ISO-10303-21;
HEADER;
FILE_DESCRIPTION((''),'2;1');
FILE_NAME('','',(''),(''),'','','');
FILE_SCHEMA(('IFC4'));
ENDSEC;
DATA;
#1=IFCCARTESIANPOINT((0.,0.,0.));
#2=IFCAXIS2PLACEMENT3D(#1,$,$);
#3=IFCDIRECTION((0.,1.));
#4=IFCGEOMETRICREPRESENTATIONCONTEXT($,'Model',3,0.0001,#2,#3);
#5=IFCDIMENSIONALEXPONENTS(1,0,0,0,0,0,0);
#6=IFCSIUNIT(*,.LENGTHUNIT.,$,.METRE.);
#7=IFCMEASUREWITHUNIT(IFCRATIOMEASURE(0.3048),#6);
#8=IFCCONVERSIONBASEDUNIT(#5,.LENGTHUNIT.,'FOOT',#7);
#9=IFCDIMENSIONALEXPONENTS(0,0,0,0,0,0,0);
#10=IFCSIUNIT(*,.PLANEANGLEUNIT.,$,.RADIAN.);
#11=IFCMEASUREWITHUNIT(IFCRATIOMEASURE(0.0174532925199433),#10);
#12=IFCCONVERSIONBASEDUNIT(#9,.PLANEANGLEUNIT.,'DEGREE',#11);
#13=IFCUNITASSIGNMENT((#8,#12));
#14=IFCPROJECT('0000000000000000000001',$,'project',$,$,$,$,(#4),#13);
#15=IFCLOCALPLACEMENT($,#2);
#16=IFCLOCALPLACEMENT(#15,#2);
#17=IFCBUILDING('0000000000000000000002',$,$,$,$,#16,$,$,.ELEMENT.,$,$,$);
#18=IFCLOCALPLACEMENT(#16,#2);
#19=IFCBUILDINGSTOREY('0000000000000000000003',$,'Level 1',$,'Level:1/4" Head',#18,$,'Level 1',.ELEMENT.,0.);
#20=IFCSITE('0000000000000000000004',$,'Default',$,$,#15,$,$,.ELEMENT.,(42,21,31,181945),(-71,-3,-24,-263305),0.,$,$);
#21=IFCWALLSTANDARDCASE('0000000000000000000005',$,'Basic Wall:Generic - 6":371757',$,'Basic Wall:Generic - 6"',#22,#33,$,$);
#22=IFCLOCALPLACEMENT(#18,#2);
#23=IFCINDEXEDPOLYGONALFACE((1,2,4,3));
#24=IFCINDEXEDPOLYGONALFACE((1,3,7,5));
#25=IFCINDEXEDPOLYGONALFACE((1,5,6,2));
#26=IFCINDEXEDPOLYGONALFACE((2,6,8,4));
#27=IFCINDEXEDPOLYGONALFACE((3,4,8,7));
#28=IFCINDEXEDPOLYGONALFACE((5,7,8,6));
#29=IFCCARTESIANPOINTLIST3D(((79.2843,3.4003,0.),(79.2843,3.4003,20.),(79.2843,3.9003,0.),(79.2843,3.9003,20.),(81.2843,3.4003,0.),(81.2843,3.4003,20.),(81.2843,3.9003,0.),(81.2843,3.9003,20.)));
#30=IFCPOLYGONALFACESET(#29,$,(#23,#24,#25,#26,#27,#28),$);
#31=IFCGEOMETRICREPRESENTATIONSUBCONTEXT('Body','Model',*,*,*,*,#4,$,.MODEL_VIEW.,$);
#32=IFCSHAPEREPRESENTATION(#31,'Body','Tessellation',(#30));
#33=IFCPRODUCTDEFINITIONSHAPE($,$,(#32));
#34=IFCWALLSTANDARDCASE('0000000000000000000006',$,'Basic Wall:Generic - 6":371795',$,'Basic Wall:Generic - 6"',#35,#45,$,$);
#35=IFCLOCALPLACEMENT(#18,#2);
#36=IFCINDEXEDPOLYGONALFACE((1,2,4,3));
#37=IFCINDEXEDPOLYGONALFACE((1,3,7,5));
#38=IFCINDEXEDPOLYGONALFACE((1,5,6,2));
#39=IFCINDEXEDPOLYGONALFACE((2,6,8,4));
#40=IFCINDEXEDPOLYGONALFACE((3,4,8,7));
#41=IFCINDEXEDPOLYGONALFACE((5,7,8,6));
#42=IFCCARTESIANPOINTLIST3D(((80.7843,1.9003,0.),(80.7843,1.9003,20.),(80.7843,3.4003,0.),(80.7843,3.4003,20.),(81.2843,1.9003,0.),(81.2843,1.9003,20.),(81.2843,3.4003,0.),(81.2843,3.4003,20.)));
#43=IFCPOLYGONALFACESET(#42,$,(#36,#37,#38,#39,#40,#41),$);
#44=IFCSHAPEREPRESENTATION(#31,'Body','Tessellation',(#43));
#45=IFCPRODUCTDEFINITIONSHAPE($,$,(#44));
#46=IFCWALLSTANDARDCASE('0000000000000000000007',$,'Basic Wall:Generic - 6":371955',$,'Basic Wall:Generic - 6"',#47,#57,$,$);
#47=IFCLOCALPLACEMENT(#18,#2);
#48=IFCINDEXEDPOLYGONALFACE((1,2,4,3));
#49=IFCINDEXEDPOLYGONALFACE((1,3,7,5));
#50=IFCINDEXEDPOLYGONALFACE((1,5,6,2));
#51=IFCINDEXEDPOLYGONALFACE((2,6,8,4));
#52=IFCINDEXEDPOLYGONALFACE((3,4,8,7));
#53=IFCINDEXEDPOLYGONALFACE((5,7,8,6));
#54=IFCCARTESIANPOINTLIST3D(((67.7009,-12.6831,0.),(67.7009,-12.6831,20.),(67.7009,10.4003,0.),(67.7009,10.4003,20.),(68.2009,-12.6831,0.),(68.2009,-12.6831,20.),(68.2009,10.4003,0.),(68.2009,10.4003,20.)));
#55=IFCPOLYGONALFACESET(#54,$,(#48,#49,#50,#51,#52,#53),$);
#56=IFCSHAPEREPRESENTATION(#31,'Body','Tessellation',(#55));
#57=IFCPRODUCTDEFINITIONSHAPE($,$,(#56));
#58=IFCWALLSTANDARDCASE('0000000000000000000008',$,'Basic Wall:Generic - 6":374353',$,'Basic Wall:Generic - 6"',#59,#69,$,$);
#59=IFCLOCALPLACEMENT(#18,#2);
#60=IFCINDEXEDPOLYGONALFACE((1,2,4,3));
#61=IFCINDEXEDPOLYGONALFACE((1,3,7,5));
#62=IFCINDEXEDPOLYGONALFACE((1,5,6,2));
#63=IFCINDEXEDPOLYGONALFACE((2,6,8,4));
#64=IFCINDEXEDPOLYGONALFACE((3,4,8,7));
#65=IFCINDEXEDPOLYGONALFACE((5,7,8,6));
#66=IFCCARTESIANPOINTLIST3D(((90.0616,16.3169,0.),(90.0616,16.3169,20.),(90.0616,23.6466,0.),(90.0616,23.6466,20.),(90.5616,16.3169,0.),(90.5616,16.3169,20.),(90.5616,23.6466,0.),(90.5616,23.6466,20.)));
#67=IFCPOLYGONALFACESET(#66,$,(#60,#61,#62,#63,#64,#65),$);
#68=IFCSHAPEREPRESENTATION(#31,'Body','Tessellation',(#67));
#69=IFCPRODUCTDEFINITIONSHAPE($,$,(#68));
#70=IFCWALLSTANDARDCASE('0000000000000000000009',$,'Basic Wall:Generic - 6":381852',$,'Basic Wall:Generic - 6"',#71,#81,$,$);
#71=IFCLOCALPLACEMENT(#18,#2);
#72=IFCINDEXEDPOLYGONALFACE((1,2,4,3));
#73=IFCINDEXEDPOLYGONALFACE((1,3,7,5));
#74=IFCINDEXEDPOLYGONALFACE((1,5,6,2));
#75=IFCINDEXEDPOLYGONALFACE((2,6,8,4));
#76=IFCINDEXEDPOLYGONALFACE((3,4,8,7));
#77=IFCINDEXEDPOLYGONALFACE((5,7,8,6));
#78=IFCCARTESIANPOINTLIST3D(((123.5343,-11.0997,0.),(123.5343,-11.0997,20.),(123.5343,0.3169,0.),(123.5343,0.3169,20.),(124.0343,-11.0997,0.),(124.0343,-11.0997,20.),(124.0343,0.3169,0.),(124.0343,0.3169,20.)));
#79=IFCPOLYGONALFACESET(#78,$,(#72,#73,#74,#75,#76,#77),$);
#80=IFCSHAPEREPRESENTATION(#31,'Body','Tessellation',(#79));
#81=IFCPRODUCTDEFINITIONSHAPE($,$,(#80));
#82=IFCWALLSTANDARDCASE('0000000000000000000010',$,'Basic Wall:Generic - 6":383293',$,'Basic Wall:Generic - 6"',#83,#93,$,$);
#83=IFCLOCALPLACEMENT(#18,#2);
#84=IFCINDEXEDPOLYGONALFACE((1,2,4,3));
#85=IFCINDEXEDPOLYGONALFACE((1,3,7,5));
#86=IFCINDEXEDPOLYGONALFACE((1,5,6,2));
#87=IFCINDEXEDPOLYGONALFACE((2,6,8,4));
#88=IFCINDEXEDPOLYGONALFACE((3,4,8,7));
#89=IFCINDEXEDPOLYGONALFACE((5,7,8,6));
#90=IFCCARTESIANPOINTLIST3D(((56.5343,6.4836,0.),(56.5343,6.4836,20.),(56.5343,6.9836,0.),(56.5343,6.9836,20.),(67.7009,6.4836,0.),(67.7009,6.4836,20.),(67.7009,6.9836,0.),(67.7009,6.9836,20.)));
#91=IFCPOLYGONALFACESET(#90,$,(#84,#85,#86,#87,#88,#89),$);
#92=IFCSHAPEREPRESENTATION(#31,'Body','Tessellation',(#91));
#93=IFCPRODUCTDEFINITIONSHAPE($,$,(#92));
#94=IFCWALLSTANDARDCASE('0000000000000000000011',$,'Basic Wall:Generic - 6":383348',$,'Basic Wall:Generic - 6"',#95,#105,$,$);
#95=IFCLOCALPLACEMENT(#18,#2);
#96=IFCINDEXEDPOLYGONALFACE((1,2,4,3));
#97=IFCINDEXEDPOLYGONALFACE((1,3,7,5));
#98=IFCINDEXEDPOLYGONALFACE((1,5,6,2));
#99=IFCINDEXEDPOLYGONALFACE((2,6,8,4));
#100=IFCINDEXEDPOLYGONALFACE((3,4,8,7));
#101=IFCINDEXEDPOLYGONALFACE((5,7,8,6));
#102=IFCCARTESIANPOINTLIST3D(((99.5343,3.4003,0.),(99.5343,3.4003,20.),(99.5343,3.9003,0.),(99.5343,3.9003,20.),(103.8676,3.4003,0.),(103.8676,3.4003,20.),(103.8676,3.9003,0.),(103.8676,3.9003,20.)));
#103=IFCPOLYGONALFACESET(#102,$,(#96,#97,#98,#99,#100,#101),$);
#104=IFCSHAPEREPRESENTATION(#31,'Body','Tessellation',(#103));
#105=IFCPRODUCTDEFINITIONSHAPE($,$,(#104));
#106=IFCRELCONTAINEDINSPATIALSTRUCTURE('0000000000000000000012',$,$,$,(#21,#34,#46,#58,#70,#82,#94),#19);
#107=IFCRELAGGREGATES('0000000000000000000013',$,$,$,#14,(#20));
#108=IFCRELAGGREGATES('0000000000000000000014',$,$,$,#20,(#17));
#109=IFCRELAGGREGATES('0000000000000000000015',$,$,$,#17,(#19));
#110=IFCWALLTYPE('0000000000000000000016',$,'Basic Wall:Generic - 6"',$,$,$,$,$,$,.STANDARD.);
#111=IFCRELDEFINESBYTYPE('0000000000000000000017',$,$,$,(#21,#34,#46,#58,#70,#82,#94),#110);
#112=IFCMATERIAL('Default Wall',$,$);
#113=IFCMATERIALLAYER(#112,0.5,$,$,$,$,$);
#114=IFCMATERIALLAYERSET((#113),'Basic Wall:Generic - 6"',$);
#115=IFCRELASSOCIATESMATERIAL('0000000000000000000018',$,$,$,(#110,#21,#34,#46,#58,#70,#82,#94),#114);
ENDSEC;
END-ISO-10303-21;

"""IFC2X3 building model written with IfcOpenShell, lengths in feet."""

from ifc_helpers import new_model, entity, si_unit, converted_unit, direction, frame, frame_2d, origin, place, context, subcontext, project, spatial, rectangle, extrude, material, layer, layer_set, layer_usage, type_object, element, save


model = new_model("IFC2X3")

# Units and contexts
model_context = context("Model", 3, precision=0.0001, world=origin(), true_north=direction((0.0, 1.0)))
body_context = subcontext(model_context, "Body", "Model", "MODEL_VIEW")
ifc_project = project(units=[converted_unit("LENGTHUNIT", "FOOT", entity("IfcRatioMeasure", 0.3048), si_unit("LENGTHUNIT", "METRE"), dimensions=[1, 0, 0, 0, 0, 0, 0]), converted_unit("PLANEANGLEUNIT", "DEGREE", entity("IfcRatioMeasure", 0.0174532925199433), si_unit("PLANEANGLEUNIT", "RADIAN"), dimensions=[0, 0, 0, 0, 0, 0, 0])], contexts=[model_context])

# Site, building, storey
site_placement = place(None, origin())
site = spatial("IfcSite", under=ifc_project, at=site_placement, Name="Default", CompositionType="ELEMENT", RefLatitude=(42, 21, 31, 181945), RefLongitude=(-71, -3, -24, -263305), RefElevation=0.0)
building_placement = place(site_placement, origin())
building = spatial("IfcBuilding", under=site, at=building_placement, CompositionType="ELEMENT")
storey_placement = place(building_placement, origin())
storey = spatial("IfcBuildingStorey", under=building, at=storey_placement, Name="Level 1", ObjectType="Level:1/4\" Head", LongName="Level 1", CompositionType="ELEMENT", Elevation=0.0)

# Walls
ifc_material = material(Name="Default Wall")
ifc_layer_1 = layer(ifc_material, 0.5)
ifc_layer_set_1 = layer_set([ifc_layer_1], Name="Basic Wall:Generic - 6\"")
wall_type_1 = type_object("IfcWallType", Name="Basic Wall:Generic - 6\"", PredefinedType="STANDARD", material=ifc_layer_set_1)
ifc_layer_usage_1 = layer_usage(ifc_layer_set_1, "AXIS2", "NEGATIVE", 0.25)
wall_1_placement = place(storey_placement, frame((79.2843, 3.6503, 0.0)))
element("IfcWallStandardCase", 1, at=wall_1_placement, inside=storey, type_object=wall_type_1, material=ifc_layer_usage_1, Name="Basic Wall:Generic - 6\":371757", ObjectType="Basic Wall:Generic - 6\"", context=body_context, shape_type="SweptSolid", body=[
    extrude(rectangle(XDim=2.0, YDim=0.5, at=frame_2d((1.0, 0.0), x_axis=(-1.0, 0.0))), origin(), (0.0, 0.0, 1.0), 20.0),
])
ifc_layer_usage_2 = layer_usage(ifc_layer_set_1, "AXIS2", "NEGATIVE", 0.25)
wall_2_placement = place(storey_placement, frame((81.0343, 3.4003, 0.0), z_axis=(0.0, 0.0, 1.0), x_axis=(0.0, -1.0, 0.0)))
element("IfcWallStandardCase", 2, at=wall_2_placement, inside=storey, type_object=wall_type_1, material=ifc_layer_usage_2, Name="Basic Wall:Generic - 6\":371795", ObjectType="Basic Wall:Generic - 6\"", context=body_context, shape_type="SweptSolid", body=[
    extrude(rectangle(XDim=1.5, YDim=0.5, at=frame_2d((0.75, 0.0), x_axis=(-1.0, 0.0))), origin(), (0.0, 0.0, 1.0), 20.0),
])
ifc_layer_usage_3 = layer_usage(ifc_layer_set_1, "AXIS2", "NEGATIVE", 0.25)
wall_3_placement = place(storey_placement, frame((67.9509, 10.4003, 0.0), z_axis=(0.0, 0.0, 1.0), x_axis=(0.0, -1.0, 0.0)))
element("IfcWallStandardCase", 3, at=wall_3_placement, inside=storey, type_object=wall_type_1, material=ifc_layer_usage_3, Name="Basic Wall:Generic - 6\":371955", ObjectType="Basic Wall:Generic - 6\"", context=body_context, shape_type="SweptSolid", body=[
    extrude(rectangle(XDim=23.0833, YDim=0.5, at=frame_2d((11.5417, 0.0), x_axis=(-1.0, 0.0))), origin(), (0.0, 0.0, 1.0), 20.0),
])
ifc_layer_usage_4 = layer_usage(ifc_layer_set_1, "AXIS2", "NEGATIVE", 0.25)
wall_4_placement = place(storey_placement, frame((90.3116, 16.3169, 0.0), z_axis=(0.0, 0.0, 1.0), x_axis=(0.0, 1.0, 0.0)))
element("IfcWallStandardCase", 4, at=wall_4_placement, inside=storey, type_object=wall_type_1, material=ifc_layer_usage_4, Name="Basic Wall:Generic - 6\":374353", ObjectType="Basic Wall:Generic - 6\"", context=body_context, shape_type="SweptSolid", body=[
    extrude(rectangle(XDim=7.3297, YDim=0.5, at=frame_2d((3.6648, 0.0), x_axis=(-1.0, 0.0))), origin(), (0.0, 0.0, 1.0), 20.0),
])
ifc_layer_usage_5 = layer_usage(ifc_layer_set_1, "AXIS2", "NEGATIVE", 0.25)
wall_5_placement = place(storey_placement, frame((123.7843, 0.3169, 0.0), z_axis=(0.0, 0.0, 1.0), x_axis=(0.0, -1.0, 0.0)))
element("IfcWallStandardCase", 5, at=wall_5_placement, inside=storey, type_object=wall_type_1, material=ifc_layer_usage_5, Name="Basic Wall:Generic - 6\":381852", ObjectType="Basic Wall:Generic - 6\"", context=body_context, shape_type="SweptSolid", body=[
    extrude(rectangle(XDim=11.4167, YDim=0.5, at=frame_2d((5.7083, 0.0), x_axis=(-1.0, 0.0))), origin(), (0.0, 0.0, 1.0), 20.0),
])
ifc_layer_usage_6 = layer_usage(ifc_layer_set_1, "AXIS2", "NEGATIVE", 0.25)
wall_6_placement = place(storey_placement, frame((56.5343, 6.7336, 0.0)))
element("IfcWallStandardCase", 6, at=wall_6_placement, inside=storey, type_object=wall_type_1, material=ifc_layer_usage_6, Name="Basic Wall:Generic - 6\":383293", ObjectType="Basic Wall:Generic - 6\"", context=body_context, shape_type="SweptSolid", body=[
    extrude(rectangle(XDim=11.1667, YDim=0.5, at=frame_2d((5.5833, 0.0), x_axis=(-1.0, 0.0))), origin(), (0.0, 0.0, 1.0), 20.0),
])
ifc_layer_usage_7 = layer_usage(ifc_layer_set_1, "AXIS2", "NEGATIVE", 0.25)
wall_7_placement = place(storey_placement, frame((99.5343, 3.6503, 0.0)))
element("IfcWallStandardCase", 7, at=wall_7_placement, inside=storey, type_object=wall_type_1, material=ifc_layer_usage_7, Name="Basic Wall:Generic - 6\":383348", ObjectType="Basic Wall:Generic - 6\"", context=body_context, shape_type="SweptSolid", body=[
    extrude(rectangle(XDim=4.3333, YDim=0.5, at=frame_2d((2.1667, 0.0), x_axis=(-1.0, 0.0))), origin(), (0.0, 0.0, 1.0), 20.0),
])

save(model, "model.ifc")
